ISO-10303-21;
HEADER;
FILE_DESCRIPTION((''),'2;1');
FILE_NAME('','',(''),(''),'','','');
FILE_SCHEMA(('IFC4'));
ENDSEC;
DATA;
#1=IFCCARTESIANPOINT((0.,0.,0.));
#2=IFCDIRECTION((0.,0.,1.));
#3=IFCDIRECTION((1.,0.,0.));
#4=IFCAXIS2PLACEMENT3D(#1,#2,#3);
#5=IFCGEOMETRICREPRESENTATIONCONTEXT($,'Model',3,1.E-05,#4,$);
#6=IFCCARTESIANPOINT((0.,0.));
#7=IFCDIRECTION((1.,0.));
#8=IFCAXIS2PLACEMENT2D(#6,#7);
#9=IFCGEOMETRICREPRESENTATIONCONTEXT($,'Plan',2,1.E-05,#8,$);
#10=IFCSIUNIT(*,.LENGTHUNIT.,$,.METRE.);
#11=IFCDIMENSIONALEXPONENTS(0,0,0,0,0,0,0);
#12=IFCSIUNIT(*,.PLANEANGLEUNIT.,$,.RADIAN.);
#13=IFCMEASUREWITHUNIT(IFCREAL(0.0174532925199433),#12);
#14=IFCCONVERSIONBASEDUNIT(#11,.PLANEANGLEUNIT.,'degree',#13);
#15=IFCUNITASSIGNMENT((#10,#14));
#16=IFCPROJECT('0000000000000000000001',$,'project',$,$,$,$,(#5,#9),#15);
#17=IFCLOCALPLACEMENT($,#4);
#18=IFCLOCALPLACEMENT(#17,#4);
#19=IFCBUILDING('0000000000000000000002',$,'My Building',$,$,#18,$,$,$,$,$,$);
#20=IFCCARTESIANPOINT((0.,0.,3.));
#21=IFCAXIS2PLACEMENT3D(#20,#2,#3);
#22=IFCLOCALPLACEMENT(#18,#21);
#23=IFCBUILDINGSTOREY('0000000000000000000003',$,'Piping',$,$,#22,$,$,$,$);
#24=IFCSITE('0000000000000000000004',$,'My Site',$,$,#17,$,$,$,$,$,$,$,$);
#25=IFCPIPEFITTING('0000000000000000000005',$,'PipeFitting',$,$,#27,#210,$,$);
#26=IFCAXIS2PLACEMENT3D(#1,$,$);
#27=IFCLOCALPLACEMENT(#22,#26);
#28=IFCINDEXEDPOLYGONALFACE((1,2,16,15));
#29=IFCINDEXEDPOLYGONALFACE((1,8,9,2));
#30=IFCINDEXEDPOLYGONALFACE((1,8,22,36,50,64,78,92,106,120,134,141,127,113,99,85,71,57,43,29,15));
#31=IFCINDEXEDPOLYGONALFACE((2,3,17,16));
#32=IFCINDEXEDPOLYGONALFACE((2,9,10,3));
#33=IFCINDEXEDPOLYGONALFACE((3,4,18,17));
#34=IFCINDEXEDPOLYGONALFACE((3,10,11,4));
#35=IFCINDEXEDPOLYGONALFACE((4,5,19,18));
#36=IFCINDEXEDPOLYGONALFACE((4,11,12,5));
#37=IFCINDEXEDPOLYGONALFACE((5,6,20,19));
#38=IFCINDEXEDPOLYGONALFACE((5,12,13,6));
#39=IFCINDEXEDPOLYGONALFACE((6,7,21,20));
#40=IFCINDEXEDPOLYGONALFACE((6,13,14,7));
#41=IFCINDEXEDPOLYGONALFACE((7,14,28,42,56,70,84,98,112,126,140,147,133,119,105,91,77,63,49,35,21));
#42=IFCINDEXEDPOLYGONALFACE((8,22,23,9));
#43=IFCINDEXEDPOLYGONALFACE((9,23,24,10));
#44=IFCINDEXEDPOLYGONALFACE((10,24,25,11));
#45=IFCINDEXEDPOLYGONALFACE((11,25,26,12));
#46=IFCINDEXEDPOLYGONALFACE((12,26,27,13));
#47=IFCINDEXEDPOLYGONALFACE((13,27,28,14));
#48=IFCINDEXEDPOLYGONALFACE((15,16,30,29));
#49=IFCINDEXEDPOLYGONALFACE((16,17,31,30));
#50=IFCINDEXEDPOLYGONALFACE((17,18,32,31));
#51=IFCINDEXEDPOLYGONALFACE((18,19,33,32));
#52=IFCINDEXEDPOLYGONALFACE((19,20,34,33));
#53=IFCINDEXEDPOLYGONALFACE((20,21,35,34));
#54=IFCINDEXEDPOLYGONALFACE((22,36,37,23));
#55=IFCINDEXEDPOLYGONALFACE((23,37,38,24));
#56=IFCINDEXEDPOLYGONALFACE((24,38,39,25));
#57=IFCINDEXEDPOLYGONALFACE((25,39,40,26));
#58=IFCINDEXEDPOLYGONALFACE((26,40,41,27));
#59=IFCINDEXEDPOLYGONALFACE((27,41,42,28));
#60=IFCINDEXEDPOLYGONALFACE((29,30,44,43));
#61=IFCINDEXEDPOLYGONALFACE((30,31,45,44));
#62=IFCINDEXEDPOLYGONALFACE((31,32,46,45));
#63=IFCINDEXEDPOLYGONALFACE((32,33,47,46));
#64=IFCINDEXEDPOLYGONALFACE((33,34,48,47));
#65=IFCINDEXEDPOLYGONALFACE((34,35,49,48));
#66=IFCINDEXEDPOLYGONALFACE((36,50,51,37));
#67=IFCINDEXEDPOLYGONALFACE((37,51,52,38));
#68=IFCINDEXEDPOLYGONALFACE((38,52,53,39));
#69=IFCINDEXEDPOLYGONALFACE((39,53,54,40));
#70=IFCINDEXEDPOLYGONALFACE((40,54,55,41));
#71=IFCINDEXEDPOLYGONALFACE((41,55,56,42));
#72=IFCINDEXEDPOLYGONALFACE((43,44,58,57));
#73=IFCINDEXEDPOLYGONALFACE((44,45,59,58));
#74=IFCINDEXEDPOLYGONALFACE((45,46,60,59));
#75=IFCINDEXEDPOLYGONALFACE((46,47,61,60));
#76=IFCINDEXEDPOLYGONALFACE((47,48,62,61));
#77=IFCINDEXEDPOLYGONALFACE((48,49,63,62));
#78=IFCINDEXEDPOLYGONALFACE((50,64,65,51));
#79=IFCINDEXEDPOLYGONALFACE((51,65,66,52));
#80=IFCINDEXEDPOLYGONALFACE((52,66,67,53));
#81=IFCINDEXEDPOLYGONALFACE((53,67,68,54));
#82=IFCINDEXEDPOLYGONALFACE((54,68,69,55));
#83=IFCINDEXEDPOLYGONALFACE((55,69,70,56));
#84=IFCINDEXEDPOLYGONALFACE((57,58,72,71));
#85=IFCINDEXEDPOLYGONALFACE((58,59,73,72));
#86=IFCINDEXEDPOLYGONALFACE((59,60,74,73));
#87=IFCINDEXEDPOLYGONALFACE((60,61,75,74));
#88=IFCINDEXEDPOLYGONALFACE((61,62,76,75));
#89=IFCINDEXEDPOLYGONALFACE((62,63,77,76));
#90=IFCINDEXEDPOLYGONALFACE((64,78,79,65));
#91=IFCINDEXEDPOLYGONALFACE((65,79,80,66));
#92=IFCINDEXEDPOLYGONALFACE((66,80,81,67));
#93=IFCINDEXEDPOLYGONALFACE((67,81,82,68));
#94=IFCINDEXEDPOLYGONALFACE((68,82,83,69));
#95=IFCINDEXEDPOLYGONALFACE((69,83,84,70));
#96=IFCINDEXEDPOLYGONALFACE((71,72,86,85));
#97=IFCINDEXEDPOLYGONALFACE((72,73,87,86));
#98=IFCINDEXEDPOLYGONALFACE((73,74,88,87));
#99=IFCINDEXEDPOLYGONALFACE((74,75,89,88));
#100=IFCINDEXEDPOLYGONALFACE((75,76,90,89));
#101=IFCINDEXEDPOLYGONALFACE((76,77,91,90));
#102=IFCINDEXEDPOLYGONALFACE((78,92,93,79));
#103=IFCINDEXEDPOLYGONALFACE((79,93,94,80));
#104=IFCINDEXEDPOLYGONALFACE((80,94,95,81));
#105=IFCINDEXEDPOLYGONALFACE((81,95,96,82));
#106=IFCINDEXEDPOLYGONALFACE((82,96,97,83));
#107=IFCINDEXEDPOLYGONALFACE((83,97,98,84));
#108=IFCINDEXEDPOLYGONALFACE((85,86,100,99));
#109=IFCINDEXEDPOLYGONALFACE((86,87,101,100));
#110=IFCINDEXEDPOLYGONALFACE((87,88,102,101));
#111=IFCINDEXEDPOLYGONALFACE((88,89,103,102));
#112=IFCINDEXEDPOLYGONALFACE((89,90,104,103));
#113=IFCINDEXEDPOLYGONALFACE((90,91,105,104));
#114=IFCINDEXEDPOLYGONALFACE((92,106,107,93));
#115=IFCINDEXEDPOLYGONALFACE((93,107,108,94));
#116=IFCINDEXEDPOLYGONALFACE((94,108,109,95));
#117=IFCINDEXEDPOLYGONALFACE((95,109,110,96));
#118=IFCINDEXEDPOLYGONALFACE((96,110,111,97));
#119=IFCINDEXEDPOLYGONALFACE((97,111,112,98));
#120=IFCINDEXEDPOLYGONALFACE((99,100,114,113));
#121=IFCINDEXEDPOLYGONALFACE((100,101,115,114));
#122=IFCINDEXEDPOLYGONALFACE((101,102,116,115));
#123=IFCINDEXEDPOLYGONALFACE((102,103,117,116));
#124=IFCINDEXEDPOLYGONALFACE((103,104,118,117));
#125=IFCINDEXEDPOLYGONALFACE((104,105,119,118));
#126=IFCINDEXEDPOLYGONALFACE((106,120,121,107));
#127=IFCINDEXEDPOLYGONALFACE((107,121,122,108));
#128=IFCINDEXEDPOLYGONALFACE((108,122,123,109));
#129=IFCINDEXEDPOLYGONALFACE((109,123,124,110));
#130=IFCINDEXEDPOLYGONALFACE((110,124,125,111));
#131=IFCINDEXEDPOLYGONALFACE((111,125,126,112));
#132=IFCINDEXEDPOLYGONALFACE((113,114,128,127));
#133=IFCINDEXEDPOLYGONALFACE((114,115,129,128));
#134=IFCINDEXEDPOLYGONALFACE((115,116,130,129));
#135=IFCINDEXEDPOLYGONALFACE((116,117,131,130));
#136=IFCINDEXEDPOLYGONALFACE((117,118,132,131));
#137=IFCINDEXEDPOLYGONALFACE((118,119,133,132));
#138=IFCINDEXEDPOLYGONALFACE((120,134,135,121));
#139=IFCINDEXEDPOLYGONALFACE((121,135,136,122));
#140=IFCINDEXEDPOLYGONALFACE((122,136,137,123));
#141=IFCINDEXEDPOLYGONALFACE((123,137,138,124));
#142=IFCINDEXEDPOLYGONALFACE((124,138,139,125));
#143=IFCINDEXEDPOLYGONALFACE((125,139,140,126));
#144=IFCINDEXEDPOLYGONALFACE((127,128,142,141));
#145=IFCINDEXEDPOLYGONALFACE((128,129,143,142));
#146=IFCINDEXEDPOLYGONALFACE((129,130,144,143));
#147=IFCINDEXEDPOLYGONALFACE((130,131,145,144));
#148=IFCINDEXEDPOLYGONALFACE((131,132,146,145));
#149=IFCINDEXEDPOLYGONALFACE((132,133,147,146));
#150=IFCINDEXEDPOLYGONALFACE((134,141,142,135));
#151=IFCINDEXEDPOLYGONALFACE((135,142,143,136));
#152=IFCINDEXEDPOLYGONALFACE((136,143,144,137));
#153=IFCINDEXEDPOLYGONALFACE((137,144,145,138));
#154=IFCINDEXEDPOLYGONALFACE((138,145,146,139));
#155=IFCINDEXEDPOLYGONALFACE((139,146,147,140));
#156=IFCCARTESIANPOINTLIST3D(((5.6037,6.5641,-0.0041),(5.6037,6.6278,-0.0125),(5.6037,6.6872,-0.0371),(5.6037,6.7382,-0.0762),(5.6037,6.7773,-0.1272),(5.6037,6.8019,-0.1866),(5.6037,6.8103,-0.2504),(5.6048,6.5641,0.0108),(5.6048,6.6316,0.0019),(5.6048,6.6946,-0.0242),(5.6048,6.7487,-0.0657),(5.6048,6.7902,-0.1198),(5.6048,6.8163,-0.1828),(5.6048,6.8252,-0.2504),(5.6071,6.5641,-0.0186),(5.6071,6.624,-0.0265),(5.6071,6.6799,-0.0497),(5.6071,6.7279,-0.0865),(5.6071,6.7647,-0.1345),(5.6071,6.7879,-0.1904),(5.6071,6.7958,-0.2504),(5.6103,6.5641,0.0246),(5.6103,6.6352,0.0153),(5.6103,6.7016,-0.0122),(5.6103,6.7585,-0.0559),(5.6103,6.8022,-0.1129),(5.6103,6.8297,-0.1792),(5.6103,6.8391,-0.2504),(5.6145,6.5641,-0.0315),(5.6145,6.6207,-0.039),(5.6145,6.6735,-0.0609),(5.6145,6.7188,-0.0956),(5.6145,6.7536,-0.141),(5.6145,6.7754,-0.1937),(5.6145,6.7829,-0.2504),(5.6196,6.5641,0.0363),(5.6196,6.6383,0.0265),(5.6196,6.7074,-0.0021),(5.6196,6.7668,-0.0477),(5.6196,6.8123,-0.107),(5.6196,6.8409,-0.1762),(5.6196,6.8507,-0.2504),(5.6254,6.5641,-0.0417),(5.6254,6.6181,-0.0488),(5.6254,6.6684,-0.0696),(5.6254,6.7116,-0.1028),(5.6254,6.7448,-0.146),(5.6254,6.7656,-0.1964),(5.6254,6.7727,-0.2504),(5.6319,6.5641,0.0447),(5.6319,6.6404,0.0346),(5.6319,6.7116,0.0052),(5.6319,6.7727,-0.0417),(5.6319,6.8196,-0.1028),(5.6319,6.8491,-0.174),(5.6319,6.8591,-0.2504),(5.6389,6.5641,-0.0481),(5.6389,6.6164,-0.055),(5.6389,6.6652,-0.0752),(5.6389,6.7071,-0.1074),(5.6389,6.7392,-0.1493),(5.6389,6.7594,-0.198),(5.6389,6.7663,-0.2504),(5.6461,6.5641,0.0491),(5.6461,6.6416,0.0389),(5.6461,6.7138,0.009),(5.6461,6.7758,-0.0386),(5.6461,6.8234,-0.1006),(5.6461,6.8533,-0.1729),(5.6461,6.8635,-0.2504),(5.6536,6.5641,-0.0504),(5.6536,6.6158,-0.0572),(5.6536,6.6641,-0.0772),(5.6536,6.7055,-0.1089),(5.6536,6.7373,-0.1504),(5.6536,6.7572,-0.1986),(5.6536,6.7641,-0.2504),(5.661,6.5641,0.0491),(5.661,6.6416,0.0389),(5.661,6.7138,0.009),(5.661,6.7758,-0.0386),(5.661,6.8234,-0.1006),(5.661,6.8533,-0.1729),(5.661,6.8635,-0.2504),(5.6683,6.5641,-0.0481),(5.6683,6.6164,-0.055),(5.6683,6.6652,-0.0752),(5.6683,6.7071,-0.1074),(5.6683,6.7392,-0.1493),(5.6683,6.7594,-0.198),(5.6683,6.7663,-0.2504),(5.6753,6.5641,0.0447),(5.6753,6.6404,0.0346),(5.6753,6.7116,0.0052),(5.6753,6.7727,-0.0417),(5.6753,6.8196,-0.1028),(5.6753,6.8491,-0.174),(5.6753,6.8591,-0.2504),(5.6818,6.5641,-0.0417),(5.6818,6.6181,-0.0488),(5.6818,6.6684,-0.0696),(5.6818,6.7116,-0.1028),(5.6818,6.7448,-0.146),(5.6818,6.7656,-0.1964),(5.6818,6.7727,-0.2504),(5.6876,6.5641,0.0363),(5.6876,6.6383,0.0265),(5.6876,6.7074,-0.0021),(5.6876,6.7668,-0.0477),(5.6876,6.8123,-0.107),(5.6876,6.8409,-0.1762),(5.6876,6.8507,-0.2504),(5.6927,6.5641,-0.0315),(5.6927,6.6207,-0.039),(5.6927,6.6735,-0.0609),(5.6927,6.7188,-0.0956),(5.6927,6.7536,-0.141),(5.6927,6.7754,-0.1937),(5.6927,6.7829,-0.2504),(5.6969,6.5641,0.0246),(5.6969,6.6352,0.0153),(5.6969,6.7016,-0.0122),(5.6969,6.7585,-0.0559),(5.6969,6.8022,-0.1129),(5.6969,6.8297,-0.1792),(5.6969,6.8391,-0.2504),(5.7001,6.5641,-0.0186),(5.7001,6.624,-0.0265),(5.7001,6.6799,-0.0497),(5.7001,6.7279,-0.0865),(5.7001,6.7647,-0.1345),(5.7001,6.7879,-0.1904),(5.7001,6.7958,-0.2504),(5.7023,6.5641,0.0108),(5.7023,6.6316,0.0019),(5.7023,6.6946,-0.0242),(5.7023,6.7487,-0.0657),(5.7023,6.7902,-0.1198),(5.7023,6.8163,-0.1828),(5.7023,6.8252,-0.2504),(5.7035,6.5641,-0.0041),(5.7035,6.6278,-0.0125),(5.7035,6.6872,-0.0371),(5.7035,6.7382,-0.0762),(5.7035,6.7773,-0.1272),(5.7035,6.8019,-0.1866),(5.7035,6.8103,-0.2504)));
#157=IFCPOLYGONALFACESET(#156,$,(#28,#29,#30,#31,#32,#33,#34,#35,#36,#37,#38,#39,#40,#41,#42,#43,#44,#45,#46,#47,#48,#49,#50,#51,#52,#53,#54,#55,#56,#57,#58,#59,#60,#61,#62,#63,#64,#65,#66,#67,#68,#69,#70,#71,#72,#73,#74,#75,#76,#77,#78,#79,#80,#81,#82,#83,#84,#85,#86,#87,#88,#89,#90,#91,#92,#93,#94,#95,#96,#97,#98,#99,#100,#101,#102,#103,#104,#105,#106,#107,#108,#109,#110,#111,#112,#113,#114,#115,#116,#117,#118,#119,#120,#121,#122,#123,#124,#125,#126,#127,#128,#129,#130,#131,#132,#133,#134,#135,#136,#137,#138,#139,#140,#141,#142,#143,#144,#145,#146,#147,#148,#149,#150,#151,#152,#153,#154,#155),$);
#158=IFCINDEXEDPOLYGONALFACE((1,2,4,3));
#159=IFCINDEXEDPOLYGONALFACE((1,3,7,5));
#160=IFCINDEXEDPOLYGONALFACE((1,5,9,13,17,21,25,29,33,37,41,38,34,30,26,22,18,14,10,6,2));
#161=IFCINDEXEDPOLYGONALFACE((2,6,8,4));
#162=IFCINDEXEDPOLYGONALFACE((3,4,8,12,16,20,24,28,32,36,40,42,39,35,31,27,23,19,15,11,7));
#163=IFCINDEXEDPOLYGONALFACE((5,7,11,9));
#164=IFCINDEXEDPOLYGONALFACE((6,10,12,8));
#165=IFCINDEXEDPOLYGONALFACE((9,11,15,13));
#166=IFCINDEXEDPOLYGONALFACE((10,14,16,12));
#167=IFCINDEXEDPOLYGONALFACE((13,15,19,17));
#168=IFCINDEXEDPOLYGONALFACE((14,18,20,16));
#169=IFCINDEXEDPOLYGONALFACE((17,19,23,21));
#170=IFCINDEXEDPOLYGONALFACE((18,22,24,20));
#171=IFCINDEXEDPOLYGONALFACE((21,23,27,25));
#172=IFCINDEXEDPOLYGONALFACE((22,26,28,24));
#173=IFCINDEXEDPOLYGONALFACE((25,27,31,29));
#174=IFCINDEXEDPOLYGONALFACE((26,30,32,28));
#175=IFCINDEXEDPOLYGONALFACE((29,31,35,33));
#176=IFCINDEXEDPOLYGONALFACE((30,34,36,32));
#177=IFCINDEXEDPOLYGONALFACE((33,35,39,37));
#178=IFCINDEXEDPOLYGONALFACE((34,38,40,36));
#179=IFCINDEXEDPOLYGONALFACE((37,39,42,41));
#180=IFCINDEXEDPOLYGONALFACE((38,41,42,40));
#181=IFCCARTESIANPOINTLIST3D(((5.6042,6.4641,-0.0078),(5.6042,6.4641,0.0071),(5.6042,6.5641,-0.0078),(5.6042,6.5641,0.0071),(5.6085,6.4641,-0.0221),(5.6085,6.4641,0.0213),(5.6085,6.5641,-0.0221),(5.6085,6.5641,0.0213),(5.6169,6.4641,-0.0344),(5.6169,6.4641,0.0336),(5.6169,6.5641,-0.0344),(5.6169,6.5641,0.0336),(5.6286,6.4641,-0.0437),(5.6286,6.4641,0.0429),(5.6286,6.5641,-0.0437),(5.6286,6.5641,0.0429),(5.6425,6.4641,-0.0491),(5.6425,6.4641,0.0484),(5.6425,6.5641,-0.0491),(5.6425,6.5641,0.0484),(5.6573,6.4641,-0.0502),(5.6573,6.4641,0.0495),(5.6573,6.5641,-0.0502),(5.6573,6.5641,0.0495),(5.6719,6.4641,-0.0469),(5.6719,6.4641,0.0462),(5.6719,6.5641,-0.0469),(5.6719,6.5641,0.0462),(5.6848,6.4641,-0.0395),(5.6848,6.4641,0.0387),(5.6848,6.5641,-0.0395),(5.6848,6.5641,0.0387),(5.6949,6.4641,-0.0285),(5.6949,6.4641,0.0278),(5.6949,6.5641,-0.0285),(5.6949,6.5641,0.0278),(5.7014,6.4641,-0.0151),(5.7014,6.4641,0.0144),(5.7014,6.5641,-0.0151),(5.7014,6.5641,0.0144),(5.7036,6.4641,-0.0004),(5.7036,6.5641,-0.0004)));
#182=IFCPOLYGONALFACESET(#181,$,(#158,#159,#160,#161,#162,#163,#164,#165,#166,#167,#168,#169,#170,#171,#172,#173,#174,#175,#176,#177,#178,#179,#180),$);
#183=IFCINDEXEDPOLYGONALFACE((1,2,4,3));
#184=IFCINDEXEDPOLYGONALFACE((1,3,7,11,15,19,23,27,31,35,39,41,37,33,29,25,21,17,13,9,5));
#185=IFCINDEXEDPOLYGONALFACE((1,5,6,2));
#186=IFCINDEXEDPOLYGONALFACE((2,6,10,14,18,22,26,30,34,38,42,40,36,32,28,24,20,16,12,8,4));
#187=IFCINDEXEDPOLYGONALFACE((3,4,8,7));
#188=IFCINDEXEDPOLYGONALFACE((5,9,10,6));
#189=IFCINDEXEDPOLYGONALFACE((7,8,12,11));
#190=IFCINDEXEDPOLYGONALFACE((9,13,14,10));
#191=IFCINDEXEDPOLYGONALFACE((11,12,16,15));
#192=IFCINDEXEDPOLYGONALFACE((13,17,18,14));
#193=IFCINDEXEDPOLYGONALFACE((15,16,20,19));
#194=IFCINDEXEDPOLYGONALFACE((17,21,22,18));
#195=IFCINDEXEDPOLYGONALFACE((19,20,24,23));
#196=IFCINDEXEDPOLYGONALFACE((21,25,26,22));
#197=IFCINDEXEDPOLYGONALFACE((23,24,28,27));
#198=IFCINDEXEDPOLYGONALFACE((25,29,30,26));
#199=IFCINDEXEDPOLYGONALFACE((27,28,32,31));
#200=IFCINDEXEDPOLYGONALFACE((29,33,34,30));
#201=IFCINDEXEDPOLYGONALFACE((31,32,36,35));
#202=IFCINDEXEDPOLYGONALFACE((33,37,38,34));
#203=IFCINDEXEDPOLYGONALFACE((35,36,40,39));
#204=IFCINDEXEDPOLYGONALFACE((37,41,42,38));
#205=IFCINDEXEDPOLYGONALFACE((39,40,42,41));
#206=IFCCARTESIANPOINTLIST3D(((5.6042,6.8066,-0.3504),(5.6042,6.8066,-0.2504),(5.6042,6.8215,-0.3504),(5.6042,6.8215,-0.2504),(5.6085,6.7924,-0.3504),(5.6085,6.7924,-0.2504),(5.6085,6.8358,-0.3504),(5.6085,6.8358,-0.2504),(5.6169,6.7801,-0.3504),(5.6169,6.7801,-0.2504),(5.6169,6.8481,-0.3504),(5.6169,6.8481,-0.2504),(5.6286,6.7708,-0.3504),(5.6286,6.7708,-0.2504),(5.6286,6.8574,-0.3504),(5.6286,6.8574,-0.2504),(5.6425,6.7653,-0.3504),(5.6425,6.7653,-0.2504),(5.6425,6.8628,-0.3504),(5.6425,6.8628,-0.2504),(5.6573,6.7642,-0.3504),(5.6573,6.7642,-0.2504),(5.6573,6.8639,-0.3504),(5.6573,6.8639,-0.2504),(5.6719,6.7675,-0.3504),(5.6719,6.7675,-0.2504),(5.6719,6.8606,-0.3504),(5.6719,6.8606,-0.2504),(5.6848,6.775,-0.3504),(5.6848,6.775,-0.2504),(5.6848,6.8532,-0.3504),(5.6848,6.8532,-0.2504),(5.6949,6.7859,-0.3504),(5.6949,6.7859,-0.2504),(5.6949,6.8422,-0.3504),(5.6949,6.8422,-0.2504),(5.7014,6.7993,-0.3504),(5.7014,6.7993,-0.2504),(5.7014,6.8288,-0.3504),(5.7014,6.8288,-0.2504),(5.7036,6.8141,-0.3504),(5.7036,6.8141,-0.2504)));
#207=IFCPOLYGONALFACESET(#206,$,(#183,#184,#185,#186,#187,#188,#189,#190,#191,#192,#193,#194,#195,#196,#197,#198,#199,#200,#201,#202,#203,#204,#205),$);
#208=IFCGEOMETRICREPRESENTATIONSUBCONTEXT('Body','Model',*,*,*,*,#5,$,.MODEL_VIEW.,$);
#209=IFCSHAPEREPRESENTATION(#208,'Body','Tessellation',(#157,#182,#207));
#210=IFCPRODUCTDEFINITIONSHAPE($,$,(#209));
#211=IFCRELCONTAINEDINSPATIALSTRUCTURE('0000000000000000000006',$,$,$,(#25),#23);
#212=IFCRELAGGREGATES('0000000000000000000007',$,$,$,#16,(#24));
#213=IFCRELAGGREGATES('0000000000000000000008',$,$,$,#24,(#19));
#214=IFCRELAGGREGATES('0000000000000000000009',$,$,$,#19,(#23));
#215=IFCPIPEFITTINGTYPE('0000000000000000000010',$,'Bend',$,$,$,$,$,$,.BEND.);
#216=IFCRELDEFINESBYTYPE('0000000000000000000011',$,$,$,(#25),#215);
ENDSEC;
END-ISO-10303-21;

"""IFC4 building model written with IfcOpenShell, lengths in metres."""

from ifc_helpers import new_model, entity, si_unit, converted_unit, frame, origin_with_axes, origin_2d_with_axis, place, context, subcontext, project, spatial, circle, extrude, source, transform, mapped, type_object, type_shapes, element, save


model = new_model("IFC4")

# Units and contexts
model_context = context("Model", 3, precision=1e-05, world=origin_with_axes())
plan_context = context("Plan", 2, precision=1e-05, world=origin_2d_with_axis())
body_context = subcontext(model_context, "Body", "Model", "MODEL_VIEW")
ifc_project = project(units=[si_unit("LENGTHUNIT", "METRE"), converted_unit("PLANEANGLEUNIT", "degree", entity("IfcReal", 0.0174532925199433), si_unit("PLANEANGLEUNIT", "RADIAN"), dimensions=[0, 0, 0, 0, 0, 0, 0])], contexts=[model_context, plan_context])

# Site, building, storey
site_placement = place(None, origin_with_axes())
site = spatial("IfcSite", under=ifc_project, at=site_placement, Name="My Site")
building_placement = place(site_placement, origin_with_axes())
building = spatial("IfcBuilding", under=site, at=building_placement, Name="My Building")
storey_placement = place(building_placement, frame((0.0, 0.0, 3.0), z_axis=(0.0, 0.0, 1.0), x_axis=(1.0, 0.0, 0.0)))
storey = spatial("IfcBuildingStorey", under=building, at=storey_placement, Name="Piping")

# Shared definitions
pipe_fitting_type = type_object("IfcPipeFittingType", Name="Bend", PredefinedType="BEND")
shared_shape = source(origin_with_axes(), body_context, "Body", "SolidModel", [
    entity("IfcSweptDiskSolid", entity("IfcIndexedPolyCurve", entity("IfcCartesianPointList3D", [[0.0, 0.0, -0.1], [0.0, -0.0732, -0.2768], [0.0, -0.25, -0.35]]), [entity("IfcArcIndex", [1, 2, 3])]), 0.05),
    extrude(circle(Radius=0.05), origin_with_axes(), (0.0, 0.0, -1.0), 0.1),
    extrude(circle(Radius=0.05), frame((0.0, -0.25, -0.35), z_axis=(0.0, -1.0, 0.0), x_axis=(1.0, 0.0, 0.0)), (0.0, 0.0, 1.0), 0.1),
])
type_shapes(pipe_fitting_type, [shared_shape])

# Pipe fitting
for number, where, z_axis, x_axis, name in (
    (1, (5.6536, 6.4641, -0.0004), (0.0, -1.0, 0.0), (1.0, 0.0, 0.0), "PipeFitting"),
):
    element("IfcPipeFitting", number, at=place(storey_placement, frame(where, z_axis=z_axis, x_axis=x_axis)), inside=storey, type_object=pipe_fitting_type, Name=name, context=body_context, shape_type="MappedRepresentation", body=[
        mapped(shared_shape, transform((0.0, 0.0, 0.0), x_axis=(1.0, 0.0, 0.0), y_axis=(0.0, 1.0, 0.0), z_axis=(0.0, 0.0, 1.0), scale=1.0)),
    ])

save(model, "model.ifc")
